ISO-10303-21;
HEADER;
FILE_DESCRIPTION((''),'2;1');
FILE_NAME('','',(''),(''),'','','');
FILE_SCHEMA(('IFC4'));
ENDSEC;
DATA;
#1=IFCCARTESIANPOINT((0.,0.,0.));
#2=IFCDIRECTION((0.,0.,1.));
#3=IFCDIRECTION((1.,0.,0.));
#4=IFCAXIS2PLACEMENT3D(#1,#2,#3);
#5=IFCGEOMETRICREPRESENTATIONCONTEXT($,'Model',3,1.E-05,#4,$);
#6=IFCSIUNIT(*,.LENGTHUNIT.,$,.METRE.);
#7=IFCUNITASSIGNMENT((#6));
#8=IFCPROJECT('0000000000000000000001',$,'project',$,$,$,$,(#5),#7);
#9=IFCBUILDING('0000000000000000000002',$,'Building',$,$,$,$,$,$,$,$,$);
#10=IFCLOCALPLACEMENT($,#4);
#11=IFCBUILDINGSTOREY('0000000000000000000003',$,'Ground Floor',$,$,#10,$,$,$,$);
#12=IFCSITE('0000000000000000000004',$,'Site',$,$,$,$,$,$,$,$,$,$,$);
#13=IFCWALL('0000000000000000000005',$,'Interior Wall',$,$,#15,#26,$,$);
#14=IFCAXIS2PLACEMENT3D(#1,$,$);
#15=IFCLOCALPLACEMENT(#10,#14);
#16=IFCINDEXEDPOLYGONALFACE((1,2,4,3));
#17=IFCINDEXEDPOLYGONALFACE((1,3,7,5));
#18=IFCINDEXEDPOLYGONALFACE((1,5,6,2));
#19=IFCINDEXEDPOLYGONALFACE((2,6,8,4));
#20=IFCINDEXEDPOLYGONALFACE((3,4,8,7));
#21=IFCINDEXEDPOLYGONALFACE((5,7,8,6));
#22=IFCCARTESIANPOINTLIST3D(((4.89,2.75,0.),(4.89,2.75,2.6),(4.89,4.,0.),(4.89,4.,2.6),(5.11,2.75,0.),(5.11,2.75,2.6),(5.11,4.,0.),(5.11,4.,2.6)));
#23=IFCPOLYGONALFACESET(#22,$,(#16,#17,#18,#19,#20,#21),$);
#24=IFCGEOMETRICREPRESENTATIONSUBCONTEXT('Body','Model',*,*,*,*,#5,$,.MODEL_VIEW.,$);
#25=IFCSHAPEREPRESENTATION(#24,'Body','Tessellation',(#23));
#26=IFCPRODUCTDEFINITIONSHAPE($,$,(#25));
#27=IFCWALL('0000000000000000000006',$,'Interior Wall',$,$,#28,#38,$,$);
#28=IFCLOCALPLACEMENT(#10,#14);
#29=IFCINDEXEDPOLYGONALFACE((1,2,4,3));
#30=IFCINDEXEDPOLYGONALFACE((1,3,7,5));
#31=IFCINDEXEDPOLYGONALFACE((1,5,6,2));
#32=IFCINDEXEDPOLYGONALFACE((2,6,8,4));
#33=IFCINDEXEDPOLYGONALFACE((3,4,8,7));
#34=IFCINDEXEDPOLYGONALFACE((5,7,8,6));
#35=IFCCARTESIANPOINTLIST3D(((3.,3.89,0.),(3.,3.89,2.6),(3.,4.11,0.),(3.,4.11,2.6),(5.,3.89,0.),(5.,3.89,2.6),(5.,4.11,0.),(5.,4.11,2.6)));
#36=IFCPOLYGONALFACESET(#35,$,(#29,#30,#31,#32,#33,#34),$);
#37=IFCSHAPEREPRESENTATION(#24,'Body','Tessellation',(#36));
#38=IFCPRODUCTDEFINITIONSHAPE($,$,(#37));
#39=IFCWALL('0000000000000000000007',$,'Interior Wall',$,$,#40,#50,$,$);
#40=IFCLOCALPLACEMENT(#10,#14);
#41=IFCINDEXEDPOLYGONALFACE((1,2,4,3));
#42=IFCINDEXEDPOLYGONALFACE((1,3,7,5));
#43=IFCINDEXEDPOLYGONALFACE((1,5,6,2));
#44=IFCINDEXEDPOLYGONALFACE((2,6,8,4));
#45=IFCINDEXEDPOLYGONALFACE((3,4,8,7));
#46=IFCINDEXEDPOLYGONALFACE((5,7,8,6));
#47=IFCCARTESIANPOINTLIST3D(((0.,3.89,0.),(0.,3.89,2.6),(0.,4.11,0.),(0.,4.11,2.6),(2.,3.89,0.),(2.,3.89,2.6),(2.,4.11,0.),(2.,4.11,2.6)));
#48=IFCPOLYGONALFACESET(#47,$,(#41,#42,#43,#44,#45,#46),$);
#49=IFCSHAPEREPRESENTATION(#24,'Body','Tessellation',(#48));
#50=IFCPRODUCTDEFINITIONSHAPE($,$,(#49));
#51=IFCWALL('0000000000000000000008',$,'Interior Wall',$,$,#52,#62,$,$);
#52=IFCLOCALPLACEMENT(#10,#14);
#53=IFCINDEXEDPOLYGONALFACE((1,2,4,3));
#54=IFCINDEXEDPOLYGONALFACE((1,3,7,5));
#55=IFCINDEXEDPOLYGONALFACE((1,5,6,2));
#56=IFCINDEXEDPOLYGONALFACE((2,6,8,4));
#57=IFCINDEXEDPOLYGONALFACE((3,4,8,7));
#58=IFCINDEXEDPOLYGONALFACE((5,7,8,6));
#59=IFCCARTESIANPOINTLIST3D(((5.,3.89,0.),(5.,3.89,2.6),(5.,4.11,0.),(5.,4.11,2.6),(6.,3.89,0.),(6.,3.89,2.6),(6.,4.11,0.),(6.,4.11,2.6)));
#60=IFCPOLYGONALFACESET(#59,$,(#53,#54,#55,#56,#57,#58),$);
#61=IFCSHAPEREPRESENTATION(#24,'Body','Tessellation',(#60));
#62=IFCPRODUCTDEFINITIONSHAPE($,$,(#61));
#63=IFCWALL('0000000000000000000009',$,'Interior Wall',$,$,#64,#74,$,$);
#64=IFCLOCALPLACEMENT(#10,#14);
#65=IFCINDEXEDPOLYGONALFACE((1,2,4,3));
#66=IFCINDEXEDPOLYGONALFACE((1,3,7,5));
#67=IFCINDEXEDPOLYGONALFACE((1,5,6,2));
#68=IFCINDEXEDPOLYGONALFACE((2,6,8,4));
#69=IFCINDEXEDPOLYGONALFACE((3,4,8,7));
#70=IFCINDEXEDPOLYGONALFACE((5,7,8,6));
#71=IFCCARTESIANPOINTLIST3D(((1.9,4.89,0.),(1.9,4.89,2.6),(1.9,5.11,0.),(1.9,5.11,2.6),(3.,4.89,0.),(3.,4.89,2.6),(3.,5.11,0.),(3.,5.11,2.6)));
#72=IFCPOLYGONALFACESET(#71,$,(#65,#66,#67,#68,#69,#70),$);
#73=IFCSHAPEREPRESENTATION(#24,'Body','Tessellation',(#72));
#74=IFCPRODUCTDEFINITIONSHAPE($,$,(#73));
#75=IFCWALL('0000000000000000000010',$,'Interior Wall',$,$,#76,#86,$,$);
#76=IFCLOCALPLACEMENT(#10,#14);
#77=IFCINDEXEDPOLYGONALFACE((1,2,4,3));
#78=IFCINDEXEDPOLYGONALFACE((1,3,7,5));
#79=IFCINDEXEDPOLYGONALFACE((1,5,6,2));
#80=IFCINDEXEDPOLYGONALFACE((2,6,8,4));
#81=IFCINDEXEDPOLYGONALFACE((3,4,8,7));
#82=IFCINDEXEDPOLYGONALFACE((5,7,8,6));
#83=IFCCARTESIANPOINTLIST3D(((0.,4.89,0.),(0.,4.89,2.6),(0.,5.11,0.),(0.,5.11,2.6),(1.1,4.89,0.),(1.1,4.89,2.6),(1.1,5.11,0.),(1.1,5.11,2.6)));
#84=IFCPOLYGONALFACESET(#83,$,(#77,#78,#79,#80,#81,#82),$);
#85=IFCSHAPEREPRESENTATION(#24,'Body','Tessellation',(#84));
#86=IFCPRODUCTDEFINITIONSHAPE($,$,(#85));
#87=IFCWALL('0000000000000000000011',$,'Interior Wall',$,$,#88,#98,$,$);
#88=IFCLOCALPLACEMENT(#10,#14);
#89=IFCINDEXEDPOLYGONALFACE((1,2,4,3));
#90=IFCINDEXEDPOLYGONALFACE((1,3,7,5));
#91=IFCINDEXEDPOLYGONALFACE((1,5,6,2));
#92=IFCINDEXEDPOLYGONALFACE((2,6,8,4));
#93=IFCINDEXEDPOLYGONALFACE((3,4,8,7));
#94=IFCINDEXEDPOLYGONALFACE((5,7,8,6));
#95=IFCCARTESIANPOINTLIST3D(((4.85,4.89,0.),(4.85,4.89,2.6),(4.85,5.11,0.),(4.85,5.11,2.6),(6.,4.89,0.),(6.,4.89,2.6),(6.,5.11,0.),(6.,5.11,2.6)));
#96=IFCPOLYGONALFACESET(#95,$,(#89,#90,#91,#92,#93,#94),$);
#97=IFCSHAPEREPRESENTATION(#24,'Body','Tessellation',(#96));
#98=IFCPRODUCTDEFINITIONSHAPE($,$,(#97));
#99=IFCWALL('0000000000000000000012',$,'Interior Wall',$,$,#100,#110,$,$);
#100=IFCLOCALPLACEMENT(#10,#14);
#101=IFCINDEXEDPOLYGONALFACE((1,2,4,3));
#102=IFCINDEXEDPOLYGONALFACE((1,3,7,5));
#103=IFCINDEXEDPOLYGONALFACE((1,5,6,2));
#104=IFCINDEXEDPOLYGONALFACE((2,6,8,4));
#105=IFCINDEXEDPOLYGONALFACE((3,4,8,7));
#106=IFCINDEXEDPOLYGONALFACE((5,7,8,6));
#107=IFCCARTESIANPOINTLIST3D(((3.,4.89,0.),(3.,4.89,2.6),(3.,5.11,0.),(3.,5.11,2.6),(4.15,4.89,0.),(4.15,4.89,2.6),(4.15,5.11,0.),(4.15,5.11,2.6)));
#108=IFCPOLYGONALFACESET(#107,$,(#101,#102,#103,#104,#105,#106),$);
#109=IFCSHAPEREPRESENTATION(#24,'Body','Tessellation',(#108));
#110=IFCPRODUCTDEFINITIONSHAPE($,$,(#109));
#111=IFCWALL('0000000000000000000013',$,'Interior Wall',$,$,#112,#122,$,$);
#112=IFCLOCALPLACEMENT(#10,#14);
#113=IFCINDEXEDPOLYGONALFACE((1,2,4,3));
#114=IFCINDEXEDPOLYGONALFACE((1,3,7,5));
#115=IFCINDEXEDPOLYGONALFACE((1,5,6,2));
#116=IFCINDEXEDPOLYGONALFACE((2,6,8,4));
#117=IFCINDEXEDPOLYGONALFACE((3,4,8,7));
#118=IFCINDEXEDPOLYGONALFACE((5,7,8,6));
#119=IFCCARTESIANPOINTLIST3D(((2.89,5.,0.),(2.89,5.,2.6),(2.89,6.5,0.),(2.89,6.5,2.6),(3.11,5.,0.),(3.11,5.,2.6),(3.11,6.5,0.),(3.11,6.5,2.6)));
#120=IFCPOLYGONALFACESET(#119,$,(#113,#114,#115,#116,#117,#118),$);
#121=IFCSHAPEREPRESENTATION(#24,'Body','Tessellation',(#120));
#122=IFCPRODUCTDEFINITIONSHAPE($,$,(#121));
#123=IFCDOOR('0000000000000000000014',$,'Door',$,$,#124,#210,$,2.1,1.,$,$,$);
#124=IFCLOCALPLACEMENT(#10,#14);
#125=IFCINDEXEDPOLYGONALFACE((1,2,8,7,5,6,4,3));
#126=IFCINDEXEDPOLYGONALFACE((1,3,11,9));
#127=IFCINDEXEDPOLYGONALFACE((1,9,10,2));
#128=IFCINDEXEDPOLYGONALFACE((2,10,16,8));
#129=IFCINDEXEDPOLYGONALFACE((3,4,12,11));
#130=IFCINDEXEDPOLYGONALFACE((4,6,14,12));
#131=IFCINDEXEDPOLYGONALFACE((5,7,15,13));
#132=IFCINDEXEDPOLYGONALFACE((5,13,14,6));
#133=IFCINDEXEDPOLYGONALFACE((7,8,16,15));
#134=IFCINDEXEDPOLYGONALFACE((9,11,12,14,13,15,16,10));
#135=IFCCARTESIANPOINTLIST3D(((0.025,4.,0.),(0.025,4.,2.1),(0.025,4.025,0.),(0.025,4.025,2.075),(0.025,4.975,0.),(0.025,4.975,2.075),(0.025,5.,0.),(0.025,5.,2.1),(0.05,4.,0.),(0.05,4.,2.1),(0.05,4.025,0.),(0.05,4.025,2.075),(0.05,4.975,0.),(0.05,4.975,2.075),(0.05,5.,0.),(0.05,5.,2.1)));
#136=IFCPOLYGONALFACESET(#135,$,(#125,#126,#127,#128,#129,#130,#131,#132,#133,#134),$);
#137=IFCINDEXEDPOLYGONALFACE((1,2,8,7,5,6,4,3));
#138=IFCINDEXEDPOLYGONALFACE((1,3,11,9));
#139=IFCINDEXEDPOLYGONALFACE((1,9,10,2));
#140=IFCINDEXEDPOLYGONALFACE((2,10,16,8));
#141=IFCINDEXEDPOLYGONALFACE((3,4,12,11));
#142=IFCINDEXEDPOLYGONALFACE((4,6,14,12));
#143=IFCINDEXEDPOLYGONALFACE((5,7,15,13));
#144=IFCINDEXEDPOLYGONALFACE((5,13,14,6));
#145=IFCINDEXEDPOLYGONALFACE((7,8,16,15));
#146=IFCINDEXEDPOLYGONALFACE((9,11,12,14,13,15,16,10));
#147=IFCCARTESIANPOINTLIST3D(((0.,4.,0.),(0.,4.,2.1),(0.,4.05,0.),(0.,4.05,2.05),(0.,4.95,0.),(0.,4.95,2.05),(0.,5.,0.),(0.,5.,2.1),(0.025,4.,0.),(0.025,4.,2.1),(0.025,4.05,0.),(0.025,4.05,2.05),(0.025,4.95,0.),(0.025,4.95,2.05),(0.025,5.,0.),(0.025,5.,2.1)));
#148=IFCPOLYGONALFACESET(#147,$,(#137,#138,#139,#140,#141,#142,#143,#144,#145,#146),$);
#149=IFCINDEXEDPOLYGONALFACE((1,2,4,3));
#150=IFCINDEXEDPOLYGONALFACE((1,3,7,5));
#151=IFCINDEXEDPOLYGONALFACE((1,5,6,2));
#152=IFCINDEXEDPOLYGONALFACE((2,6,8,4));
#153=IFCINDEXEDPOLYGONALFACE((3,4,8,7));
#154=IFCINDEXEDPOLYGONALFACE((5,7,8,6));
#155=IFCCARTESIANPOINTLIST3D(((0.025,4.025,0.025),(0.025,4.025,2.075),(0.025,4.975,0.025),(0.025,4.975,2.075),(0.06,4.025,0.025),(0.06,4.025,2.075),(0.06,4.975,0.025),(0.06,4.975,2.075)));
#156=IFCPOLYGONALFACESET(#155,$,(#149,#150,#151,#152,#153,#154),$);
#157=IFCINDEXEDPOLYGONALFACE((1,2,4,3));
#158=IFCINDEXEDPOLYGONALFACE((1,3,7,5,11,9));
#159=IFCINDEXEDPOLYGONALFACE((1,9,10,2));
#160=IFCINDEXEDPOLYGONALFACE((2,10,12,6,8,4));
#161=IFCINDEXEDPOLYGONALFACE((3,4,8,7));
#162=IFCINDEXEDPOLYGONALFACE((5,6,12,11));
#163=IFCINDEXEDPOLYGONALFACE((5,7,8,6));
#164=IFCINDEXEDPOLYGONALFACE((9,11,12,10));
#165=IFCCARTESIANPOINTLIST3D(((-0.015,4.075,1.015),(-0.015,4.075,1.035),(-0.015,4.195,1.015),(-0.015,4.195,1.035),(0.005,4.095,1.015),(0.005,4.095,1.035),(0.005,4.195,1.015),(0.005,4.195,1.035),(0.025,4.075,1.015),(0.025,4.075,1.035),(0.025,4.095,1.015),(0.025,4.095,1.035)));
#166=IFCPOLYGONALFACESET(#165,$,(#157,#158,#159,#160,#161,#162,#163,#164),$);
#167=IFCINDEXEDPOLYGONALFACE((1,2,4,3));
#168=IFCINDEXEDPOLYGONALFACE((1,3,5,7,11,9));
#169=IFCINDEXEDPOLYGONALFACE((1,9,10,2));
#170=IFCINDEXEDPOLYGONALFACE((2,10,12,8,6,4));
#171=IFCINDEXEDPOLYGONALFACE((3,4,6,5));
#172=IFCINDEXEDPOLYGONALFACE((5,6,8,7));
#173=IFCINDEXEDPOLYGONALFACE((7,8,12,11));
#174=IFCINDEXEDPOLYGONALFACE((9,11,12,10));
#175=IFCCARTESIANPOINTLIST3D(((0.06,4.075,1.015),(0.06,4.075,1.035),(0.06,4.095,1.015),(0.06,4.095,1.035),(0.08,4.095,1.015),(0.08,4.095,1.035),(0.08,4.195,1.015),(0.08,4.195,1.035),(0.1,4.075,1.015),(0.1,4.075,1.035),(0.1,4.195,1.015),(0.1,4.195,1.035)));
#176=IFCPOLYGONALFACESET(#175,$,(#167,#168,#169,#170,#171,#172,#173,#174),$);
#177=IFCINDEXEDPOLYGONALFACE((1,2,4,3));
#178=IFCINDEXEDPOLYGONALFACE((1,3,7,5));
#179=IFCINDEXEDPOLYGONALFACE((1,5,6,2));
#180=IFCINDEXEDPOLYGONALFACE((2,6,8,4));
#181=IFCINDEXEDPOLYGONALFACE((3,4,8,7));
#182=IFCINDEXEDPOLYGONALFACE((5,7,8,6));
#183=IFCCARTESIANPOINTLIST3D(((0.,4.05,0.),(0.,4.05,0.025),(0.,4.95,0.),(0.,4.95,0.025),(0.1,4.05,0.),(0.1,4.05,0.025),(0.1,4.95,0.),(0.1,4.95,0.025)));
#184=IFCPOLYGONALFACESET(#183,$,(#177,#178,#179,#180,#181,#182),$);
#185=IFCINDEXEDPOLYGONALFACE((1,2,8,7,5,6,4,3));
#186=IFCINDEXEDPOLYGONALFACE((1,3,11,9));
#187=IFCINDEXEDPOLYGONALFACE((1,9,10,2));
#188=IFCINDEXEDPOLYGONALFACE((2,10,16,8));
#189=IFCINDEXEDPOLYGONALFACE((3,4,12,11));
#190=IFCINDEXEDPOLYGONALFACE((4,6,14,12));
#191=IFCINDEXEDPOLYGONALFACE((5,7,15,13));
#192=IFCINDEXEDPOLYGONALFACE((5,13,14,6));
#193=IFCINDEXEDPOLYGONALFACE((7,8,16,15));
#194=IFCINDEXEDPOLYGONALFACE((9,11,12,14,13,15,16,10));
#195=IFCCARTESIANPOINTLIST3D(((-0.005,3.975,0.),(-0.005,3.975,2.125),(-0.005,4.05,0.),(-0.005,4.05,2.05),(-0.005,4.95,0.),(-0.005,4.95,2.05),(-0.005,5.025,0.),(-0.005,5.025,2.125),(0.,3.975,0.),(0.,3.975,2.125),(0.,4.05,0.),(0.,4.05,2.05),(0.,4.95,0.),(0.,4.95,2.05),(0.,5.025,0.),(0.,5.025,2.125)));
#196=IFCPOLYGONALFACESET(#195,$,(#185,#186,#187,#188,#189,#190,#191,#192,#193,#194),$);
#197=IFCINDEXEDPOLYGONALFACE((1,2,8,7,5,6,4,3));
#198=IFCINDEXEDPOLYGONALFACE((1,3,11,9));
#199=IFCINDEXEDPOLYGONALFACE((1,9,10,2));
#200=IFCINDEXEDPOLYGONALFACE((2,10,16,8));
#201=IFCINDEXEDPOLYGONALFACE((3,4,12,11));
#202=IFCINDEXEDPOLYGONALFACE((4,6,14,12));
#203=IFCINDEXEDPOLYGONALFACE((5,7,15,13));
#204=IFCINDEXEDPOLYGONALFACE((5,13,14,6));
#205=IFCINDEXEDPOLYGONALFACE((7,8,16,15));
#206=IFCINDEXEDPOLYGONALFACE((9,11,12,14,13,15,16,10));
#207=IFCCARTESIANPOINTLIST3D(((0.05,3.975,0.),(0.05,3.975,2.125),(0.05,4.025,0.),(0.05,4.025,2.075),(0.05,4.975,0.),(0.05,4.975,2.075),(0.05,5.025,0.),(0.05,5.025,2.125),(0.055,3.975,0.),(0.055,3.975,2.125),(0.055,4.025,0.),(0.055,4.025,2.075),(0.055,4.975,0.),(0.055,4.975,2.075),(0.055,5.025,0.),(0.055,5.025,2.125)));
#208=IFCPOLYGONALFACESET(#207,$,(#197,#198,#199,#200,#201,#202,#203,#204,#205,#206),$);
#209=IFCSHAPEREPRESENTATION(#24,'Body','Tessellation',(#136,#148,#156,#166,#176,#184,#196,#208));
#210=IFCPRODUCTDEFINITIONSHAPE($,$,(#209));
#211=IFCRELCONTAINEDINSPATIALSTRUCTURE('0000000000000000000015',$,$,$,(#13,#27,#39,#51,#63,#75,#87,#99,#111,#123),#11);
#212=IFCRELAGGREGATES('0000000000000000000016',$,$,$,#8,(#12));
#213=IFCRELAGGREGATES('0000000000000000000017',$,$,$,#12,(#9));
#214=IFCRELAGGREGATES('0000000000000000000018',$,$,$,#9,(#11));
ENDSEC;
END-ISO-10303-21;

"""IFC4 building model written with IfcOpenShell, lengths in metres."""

from ifc_helpers import new_model, si_unit, frame, origin_with_axes, place, context, subcontext, project, spatial, line, indexed_curve, outline, extrude, element, save


model = new_model("IFC4")

# Units and contexts
model_context = context("Model", 3, precision=1e-05, world=origin_with_axes())
body_context = subcontext(model_context, "Body", "Model", "MODEL_VIEW")
ifc_project = project(units=[si_unit("LENGTHUNIT", "METRE")], contexts=[model_context])

# Site, building, storey
site = spatial("IfcSite", under=ifc_project, Name="Site")
building = spatial("IfcBuilding", under=site, Name="Building")
storey_placement = place(None, origin_with_axes())
storey = spatial("IfcBuildingStorey", under=building, at=storey_placement, Name="Ground Floor")

# Walls
for number, where, z_axis, x_axis, name in (
    (1, (5.0, 2.75, 0.0), (0.0, 0.0, 1.0), (0.0, 1.0, 0.0), "Interior Wall"),
):
    element("IfcWall", number, at=place(storey_placement, frame(where, z_axis=z_axis, x_axis=x_axis)), inside=storey, Name=name, context=body_context, shape_type="SweptSolid", body=[
        extrude(outline(indexed_curve([(0.0, 0.0), (0.0, 0.22), (1.25, 0.22), (1.25, 0.0), (0.0, 0.0)], self_intersect=False)), frame((0.0, -0.11, 0.0), z_axis=(0.0, 0.0, 1.0), x_axis=(1.0, 0.0, 0.0)), (0.0, 0.0, 1.0), 2.6),
    ])
for number, where, z_axis, x_axis, name in (
    (2, (5.0, 4.0, 0.0), (0.0, 0.0, 1.0), (-1.0, 0.0, 0.0), "Interior Wall"),
    (3, (2.0, 4.0, 0.0), (0.0, 0.0, 1.0), (-1.0, 0.0, 0.0), "Interior Wall"),
):
    element("IfcWall", number, at=place(storey_placement, frame(where, z_axis=z_axis, x_axis=x_axis)), inside=storey, Name=name, context=body_context, shape_type="SweptSolid", body=[
        extrude(outline(indexed_curve([(0.0, 0.0), (0.0, 0.22), (2.0, 0.22), (2.0, 0.0), (0.0, 0.0)], self_intersect=False)), frame((0.0, -0.11, 0.0), z_axis=(0.0, 0.0, 1.0), x_axis=(1.0, 0.0, 0.0)), (0.0, 0.0, 1.0), 2.6),
    ])
wall_1_placement = place(storey_placement, frame((6.0, 4.0, 0.0), z_axis=(0.0, 0.0, 1.0), x_axis=(-1.0, 0.0, 0.0)))
element("IfcWall", 4, at=wall_1_placement, inside=storey, Name="Interior Wall", context=body_context, shape_type="SweptSolid", body=[
    extrude(outline(indexed_curve([(0.0, 0.0), (0.0, 0.22), (1.0, 0.22), (1.0, 0.0), (0.0, 0.0)], self_intersect=False)), frame((0.0, -0.11, 0.0), z_axis=(0.0, 0.0, 1.0), x_axis=(1.0, 0.0, 0.0)), (0.0, 0.0, 1.0), 2.6),
])
for number, where, z_axis, x_axis, name in (
    (5, (3.0, 5.0, 0.0), (0.0, 0.0, 1.0), (-1.0, 0.0, 0.0), "Interior Wall"),
    (6, (1.1, 5.0, 0.0), (0.0, 0.0, 1.0), (-1.0, 0.0, 0.0), "Interior Wall"),
):
    element("IfcWall", number, at=place(storey_placement, frame(where, z_axis=z_axis, x_axis=x_axis)), inside=storey, Name=name, context=body_context, shape_type="SweptSolid", body=[
        extrude(outline(indexed_curve([(0.0, 0.0), (0.0, 0.22), (1.1, 0.22), (1.1, 0.0), (0.0, 0.0)], self_intersect=False)), frame((0.0, -0.11, 0.0), z_axis=(0.0, 0.0, 1.0), x_axis=(1.0, 0.0, 0.0)), (0.0, 0.0, 1.0), 2.6),
    ])
for number, where, z_axis, x_axis, name in (
    (7, (6.0, 5.0, 0.0), (0.0, 0.0, 1.0), (-1.0, 0.0, 0.0), "Interior Wall"),
    (8, (4.15, 5.0, 0.0), (0.0, 0.0, 1.0), (-1.0, 0.0, 0.0), "Interior Wall"),
):
    element("IfcWall", number, at=place(storey_placement, frame(where, z_axis=z_axis, x_axis=x_axis)), inside=storey, Name=name, context=body_context, shape_type="SweptSolid", body=[
        extrude(outline(indexed_curve([(0.0, 0.0), (0.0, 0.22), (1.15, 0.22), (1.15, 0.0), (0.0, 0.0)], self_intersect=False)), frame((0.0, -0.11, 0.0), z_axis=(0.0, 0.0, 1.0), x_axis=(1.0, 0.0, 0.0)), (0.0, 0.0, 1.0), 2.6),
    ])
wall_2_placement = place(storey_placement, frame((3.0, 5.0, 0.0), z_axis=(0.0, 0.0, 1.0), x_axis=(0.0, 1.0, 0.0)))
element("IfcWall", 9, at=wall_2_placement, inside=storey, Name="Interior Wall", context=body_context, shape_type="SweptSolid", body=[
    extrude(outline(indexed_curve([(0.0, 0.0), (0.0, 0.22), (1.5, 0.22), (1.5, 0.0), (0.0, 0.0)], self_intersect=False)), frame((0.0, -0.11, 0.0), z_axis=(0.0, 0.0, 1.0), x_axis=(1.0, 0.0, 0.0)), (0.0, 0.0, 1.0), 2.6),
])

# Door
door_1_placement = place(storey_placement, frame((0.0, 5.0, 0.0), z_axis=(0.0, 0.0, 1.0), x_axis=(0.0, -1.0, 0.0)))
element("IfcDoor", 10, at=door_1_placement, inside=storey, Name="Door", OverallHeight=2.1, OverallWidth=1.0, context=body_context, shape_type="SweptSolid", body=[
    extrude(outline(indexed_curve([(0.0, 0.0), (0.0, 2.1), (1.0, 2.1), (1.0, 0.0), (0.975, 0.0), (0.975, 2.075), (0.025, 2.075), (0.025, 0.0)], segments=[line(1, 2, 3, 4, 5, 6, 7, 8, 1)])), frame((0.0, 0.025, 0.0), z_axis=(0.0, -1.0, 0.0), x_axis=(1.0, 0.0, 0.0)), (0.0, 0.0, -1.0), 0.025),
    extrude(outline(indexed_curve([(0.0, 0.0), (0.0, 2.1), (1.0, 2.1), (1.0, 0.0), (0.95, 0.0), (0.95, 2.05), (0.05, 2.05), (0.05, 0.0)], segments=[line(1, 2, 3, 4, 5, 6, 7, 8, 1)])), frame((0.0, 0.0, 0.0), z_axis=(0.0, -1.0, 0.0), x_axis=(1.0, 0.0, 0.0)), (0.0, 0.0, -1.0), 0.025),
    extrude(outline(indexed_curve([(0.0, 0.0), (0.95, 0.0), (0.95, 0.035), (0.0, 0.035)], segments=[line(1, 2, 3, 4, 1)])), frame((0.025, 0.025, 0.025), z_axis=(0.0, 0.0, 1.0), x_axis=(1.0, 0.0, 0.0)), (0.0, 0.0, 1.0), 2.05),
    extrude(outline(indexed_curve([(0.0, 0.0), (0.0, -0.04), (-0.12, -0.04), (-0.12, -0.02), (-0.02, -0.02), (-0.02, 0.0)], segments=[line(1, 2, 3, 4, 5, 6, 1)])), frame((0.925, 0.025, 1.015), z_axis=(0.0, 0.0, 1.0), x_axis=(1.0, 0.0, 0.0)), (0.0, 0.0, 1.0), 0.02),
    extrude(outline(indexed_curve([(0.0, 0.0), (0.0, 0.04), (-0.12, 0.04), (-0.12, 0.02), (-0.02, 0.02), (-0.02, 0.0)], segments=[line(1, 2, 3, 4, 5, 6, 1)])), frame((0.925, 0.06, 1.015), z_axis=(0.0, 0.0, 1.0), x_axis=(1.0, 0.0, 0.0)), (0.0, 0.0, 1.0), 0.02),
    extrude(outline(indexed_curve([(0.0, 0.0), (0.9, 0.0), (0.9, 0.1), (0.0, 0.1)], segments=[line(1, 2, 3, 4, 1)])), frame((0.05, 0.0, 0.0), z_axis=(0.0, 0.0, 1.0), x_axis=(1.0, 0.0, 0.0)), (0.0, 0.0, 1.0), 0.025),
    extrude(outline(indexed_curve([(0.0, 0.0), (0.0, 2.125), (1.05, 2.125), (1.05, 0.0), (0.975, 0.0), (0.975, 2.05), (0.075, 2.05), (0.075, 0.0)], segments=[line(1, 2, 3, 4, 5, 6, 7, 8, 1)])), frame((-0.025, -0.005, 0.0), z_axis=(0.0, -1.0, 0.0), x_axis=(1.0, 0.0, 0.0)), (0.0, 0.0, -1.0), 0.005),
    extrude(outline(indexed_curve([(0.0, 0.0), (0.0, 2.125), (1.05, 2.125), (1.05, 0.0), (1.0, 0.0), (1.0, 2.075), (0.05, 2.075), (0.05, 0.0)], segments=[line(1, 2, 3, 4, 5, 6, 7, 8, 1)])), frame((-0.025, 0.05, 0.0), z_axis=(0.0, -1.0, 0.0), x_axis=(1.0, 0.0, 0.0)), (0.0, 0.0, -1.0), 0.005),
])

save(model, "model.ifc")
